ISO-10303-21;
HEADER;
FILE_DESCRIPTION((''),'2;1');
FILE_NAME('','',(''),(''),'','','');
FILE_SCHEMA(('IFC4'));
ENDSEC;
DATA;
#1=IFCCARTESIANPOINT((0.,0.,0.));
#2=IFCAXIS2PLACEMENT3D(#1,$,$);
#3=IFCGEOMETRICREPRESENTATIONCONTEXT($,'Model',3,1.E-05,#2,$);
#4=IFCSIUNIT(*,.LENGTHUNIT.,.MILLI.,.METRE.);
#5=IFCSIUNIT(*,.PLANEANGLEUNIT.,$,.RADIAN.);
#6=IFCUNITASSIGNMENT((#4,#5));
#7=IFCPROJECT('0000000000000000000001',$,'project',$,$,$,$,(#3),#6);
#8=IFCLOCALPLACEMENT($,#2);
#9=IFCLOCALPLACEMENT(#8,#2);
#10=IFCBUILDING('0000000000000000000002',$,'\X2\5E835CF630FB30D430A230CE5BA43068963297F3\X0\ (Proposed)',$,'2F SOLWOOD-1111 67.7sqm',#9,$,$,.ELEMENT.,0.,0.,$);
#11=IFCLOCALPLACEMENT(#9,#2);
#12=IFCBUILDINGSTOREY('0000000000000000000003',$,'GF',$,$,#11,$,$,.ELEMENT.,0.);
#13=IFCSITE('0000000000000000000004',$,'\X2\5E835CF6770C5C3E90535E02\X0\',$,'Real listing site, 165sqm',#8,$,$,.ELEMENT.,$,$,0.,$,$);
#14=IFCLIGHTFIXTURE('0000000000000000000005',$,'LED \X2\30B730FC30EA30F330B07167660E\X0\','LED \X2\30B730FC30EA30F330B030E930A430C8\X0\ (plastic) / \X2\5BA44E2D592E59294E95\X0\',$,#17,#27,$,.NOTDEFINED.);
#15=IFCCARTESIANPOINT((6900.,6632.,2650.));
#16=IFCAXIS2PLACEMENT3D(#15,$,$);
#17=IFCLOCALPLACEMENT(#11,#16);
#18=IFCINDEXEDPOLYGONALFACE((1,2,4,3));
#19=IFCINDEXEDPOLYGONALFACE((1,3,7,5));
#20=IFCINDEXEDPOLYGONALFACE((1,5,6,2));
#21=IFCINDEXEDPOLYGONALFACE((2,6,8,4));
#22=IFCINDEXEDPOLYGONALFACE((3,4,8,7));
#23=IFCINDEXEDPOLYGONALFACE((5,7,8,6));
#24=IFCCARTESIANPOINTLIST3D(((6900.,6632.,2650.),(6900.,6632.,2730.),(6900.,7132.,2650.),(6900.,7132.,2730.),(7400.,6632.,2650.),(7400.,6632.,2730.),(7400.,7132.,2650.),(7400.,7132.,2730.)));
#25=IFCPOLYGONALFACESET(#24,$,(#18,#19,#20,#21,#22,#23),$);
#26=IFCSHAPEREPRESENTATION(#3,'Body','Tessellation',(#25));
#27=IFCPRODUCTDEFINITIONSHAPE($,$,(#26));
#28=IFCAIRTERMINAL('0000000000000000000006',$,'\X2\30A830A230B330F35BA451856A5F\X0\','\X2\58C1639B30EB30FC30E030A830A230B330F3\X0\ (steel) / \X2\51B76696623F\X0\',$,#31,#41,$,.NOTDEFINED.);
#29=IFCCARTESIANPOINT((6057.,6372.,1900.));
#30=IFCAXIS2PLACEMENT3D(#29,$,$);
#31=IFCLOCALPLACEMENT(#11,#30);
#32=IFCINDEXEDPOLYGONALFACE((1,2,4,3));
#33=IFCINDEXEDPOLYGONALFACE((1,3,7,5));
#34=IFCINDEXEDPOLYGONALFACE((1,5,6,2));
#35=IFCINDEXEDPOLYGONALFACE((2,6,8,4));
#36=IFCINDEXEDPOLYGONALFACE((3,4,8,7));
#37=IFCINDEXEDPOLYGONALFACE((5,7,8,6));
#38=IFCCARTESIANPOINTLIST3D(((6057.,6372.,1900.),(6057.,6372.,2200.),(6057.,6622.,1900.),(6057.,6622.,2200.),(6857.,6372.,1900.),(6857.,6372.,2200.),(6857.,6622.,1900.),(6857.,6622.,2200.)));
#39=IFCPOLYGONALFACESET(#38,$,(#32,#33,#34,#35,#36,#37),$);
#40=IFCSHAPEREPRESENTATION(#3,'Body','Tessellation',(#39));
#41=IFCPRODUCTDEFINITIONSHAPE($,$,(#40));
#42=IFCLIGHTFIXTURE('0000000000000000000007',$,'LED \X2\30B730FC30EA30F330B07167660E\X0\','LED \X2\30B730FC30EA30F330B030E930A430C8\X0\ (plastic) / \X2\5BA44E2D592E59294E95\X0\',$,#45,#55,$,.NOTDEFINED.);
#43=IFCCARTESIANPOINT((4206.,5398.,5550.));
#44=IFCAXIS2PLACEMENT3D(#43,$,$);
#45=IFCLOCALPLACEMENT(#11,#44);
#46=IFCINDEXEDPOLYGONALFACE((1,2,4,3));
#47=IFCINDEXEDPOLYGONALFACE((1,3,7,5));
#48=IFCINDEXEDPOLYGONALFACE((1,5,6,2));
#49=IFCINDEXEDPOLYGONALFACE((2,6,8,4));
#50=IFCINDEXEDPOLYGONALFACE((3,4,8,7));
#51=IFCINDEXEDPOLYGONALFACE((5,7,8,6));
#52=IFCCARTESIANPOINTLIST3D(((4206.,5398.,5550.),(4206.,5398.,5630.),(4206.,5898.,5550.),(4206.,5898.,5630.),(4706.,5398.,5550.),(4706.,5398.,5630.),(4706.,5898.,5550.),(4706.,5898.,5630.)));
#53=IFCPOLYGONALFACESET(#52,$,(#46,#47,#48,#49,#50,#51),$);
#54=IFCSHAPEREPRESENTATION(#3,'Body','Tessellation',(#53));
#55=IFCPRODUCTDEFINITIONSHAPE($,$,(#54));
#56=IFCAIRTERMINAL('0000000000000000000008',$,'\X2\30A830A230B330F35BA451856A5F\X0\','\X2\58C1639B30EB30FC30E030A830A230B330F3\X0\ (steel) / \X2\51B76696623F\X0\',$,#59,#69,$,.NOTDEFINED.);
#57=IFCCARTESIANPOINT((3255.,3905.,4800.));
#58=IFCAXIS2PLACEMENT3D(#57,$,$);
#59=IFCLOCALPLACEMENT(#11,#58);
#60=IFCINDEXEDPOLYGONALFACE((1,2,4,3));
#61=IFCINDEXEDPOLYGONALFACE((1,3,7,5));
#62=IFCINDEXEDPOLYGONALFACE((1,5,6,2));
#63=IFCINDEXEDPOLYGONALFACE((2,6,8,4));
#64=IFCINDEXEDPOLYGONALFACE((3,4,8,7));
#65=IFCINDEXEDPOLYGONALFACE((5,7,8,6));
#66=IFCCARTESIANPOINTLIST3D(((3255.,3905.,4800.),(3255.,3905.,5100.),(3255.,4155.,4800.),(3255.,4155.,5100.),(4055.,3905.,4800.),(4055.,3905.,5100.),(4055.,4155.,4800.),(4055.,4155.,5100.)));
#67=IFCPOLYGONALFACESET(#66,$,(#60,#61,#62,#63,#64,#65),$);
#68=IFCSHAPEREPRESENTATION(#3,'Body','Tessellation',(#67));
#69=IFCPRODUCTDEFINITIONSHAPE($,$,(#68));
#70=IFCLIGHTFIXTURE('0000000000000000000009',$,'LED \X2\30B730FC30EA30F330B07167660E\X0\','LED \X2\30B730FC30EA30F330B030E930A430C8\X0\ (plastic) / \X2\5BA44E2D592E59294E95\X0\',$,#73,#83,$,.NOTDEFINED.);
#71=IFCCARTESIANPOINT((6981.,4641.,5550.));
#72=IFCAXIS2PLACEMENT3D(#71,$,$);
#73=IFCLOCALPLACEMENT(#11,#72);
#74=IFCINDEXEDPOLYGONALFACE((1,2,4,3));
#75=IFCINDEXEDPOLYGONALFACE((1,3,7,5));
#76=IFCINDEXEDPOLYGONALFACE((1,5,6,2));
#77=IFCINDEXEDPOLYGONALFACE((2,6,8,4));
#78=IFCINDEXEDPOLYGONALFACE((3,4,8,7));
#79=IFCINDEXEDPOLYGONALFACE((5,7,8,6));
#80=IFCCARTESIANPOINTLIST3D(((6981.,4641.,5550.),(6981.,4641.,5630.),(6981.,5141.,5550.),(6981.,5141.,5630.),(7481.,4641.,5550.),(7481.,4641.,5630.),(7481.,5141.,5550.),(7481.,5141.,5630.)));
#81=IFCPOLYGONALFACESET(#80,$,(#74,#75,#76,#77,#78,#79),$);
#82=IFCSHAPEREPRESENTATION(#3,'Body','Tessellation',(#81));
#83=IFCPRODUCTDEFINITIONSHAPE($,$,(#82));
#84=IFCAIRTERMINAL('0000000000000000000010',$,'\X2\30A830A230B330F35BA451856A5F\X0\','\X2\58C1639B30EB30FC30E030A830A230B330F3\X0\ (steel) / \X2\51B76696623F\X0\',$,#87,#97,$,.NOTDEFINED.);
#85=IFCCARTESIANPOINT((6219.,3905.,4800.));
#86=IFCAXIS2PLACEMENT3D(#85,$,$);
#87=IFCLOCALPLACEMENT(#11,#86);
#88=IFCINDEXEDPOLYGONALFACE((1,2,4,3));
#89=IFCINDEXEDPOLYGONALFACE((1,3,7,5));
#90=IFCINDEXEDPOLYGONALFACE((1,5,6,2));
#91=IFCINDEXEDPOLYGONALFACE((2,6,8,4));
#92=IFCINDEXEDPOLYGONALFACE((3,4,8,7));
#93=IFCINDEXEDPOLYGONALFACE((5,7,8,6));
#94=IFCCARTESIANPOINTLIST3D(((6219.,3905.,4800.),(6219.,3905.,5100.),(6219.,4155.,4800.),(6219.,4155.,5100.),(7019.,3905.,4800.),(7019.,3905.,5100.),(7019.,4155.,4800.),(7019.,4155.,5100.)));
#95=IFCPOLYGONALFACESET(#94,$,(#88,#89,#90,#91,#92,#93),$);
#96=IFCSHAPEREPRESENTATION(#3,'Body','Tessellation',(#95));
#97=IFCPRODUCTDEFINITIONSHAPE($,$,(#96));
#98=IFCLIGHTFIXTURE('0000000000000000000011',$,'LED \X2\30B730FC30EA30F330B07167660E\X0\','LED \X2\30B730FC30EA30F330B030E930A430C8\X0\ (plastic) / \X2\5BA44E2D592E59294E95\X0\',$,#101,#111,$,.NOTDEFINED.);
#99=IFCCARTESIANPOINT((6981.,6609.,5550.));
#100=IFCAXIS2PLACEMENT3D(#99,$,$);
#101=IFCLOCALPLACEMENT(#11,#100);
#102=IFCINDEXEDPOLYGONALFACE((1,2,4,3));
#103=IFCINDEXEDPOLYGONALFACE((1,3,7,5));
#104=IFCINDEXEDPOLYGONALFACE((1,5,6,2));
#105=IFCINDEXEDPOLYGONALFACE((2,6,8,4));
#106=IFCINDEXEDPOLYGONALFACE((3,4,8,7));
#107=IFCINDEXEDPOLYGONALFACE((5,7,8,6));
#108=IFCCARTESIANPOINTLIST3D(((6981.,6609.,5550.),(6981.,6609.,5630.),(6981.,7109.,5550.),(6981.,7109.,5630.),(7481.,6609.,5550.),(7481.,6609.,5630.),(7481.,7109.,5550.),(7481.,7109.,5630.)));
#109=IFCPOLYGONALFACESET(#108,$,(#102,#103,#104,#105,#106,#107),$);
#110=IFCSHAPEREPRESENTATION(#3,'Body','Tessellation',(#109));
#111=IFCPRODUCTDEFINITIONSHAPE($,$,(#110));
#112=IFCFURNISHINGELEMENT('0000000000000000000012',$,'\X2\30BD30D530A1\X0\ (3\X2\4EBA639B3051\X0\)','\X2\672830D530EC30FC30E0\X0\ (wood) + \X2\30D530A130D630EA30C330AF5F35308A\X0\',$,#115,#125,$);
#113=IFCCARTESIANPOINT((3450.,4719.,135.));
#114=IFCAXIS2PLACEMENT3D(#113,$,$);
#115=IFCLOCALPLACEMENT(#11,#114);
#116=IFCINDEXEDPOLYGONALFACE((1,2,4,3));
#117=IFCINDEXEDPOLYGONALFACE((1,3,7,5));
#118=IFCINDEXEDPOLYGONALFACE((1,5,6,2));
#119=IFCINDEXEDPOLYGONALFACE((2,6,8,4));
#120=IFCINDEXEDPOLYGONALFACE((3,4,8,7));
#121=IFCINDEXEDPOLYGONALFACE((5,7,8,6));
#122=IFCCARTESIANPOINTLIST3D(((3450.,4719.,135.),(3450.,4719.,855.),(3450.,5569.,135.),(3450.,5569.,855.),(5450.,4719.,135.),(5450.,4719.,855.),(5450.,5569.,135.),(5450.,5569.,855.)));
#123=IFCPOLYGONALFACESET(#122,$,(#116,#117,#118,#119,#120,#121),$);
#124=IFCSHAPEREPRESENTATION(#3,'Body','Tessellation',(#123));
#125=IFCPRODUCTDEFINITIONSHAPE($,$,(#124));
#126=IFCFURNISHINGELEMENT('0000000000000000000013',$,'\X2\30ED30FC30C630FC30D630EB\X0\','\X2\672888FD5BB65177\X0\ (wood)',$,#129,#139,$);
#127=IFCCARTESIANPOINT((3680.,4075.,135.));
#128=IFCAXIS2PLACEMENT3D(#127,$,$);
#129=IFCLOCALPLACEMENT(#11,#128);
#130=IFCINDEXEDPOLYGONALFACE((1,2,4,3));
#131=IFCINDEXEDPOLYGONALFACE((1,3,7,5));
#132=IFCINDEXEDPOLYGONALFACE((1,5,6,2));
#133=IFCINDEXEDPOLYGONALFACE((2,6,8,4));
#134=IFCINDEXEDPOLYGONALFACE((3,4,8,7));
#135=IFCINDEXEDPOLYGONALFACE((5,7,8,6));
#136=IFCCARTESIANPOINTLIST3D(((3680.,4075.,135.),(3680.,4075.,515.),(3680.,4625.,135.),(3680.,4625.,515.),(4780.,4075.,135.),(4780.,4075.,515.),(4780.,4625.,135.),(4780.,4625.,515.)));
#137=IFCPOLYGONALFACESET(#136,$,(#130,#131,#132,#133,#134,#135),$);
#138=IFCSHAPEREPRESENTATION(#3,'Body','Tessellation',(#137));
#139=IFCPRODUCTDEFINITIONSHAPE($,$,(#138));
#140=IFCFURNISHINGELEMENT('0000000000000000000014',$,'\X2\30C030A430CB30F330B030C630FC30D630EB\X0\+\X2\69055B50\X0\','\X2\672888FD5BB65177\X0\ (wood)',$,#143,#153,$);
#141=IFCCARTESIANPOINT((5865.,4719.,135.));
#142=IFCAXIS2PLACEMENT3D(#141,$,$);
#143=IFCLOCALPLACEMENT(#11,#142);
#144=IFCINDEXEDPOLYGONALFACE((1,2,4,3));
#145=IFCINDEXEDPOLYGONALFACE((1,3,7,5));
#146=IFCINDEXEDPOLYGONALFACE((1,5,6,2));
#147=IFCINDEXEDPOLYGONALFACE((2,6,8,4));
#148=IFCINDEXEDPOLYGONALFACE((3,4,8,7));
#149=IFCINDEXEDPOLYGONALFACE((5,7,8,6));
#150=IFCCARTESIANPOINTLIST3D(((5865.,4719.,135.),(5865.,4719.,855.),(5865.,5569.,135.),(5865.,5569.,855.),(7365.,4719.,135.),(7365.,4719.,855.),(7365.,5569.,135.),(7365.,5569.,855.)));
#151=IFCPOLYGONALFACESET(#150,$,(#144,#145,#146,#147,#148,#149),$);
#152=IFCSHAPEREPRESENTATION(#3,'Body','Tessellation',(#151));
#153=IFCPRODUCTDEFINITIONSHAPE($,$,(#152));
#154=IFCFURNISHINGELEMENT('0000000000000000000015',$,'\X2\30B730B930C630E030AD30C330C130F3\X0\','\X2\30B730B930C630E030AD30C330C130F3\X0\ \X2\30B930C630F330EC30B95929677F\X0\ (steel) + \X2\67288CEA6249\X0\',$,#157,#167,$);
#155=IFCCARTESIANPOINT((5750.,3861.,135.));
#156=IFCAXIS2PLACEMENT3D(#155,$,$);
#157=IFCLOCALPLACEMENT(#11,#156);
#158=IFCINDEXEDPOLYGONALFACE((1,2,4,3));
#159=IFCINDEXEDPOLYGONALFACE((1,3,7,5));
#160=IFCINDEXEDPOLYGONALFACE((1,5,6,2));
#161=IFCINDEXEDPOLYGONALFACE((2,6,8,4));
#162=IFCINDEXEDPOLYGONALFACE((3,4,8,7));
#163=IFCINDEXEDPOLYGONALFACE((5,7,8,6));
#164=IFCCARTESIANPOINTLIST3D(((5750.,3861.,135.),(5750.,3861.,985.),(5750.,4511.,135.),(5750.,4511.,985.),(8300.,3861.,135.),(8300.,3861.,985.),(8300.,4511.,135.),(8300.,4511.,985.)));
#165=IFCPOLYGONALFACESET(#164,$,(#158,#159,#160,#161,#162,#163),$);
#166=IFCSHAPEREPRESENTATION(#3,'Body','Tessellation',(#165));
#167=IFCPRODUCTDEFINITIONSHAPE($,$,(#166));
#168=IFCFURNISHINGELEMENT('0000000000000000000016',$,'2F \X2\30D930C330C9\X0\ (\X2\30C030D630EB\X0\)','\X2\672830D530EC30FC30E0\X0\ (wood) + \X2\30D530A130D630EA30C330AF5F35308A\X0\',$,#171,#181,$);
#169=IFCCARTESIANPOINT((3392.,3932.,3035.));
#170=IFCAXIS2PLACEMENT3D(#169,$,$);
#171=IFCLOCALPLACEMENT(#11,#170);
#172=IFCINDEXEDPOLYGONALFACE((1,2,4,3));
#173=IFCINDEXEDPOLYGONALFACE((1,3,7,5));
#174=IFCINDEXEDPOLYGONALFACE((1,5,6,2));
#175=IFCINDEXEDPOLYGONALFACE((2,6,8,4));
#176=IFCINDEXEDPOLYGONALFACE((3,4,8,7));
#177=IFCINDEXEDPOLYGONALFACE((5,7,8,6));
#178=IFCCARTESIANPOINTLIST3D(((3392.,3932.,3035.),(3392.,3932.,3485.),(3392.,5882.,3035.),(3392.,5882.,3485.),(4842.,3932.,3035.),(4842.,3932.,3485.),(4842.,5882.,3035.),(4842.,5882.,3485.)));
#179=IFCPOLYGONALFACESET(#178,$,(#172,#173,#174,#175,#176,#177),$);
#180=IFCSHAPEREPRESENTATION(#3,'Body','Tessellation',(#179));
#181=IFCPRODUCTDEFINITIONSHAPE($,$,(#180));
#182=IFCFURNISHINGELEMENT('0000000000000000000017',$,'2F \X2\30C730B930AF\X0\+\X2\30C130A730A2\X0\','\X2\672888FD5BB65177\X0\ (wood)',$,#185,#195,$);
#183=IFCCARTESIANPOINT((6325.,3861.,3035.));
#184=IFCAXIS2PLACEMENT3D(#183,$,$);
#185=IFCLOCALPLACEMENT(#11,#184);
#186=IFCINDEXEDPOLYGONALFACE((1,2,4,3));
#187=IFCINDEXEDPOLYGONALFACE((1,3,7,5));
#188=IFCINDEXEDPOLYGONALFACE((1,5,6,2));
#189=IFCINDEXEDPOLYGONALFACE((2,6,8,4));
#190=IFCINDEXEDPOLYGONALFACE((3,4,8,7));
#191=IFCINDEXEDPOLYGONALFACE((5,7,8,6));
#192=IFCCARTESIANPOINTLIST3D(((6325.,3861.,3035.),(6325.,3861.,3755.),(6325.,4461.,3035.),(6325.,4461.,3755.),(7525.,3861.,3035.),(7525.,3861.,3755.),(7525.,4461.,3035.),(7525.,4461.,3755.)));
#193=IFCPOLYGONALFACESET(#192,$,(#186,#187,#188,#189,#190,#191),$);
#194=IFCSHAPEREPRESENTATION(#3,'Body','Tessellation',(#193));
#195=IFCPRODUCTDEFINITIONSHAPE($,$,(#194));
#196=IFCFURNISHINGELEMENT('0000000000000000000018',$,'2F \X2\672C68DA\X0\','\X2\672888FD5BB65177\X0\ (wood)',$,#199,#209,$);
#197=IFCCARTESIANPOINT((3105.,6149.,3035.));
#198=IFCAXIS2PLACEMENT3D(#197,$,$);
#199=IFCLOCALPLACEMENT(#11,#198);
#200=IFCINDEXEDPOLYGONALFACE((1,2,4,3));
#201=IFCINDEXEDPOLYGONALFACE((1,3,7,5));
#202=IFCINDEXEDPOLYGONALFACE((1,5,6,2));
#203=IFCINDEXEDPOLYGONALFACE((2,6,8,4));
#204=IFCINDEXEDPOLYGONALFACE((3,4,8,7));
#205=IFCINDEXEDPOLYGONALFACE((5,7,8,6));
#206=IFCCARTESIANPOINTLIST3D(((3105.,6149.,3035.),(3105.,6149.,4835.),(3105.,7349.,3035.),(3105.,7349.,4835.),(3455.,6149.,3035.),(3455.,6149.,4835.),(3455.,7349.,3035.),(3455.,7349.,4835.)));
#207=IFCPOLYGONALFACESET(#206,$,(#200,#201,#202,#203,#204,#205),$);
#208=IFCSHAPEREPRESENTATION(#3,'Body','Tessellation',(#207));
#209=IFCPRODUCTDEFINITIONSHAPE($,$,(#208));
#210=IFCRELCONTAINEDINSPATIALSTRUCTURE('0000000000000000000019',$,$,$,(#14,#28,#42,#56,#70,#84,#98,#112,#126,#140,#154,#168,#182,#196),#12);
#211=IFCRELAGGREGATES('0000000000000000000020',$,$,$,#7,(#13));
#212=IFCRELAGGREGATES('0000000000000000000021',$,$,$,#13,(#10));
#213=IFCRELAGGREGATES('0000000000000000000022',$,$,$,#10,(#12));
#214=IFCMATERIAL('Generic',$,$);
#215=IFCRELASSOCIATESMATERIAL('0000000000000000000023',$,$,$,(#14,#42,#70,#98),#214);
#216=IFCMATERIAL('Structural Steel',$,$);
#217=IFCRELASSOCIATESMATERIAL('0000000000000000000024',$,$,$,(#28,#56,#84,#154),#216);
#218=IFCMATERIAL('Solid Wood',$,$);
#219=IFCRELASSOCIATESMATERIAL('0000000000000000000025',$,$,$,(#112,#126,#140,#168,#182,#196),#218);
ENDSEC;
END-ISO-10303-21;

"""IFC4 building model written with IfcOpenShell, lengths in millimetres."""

from ifc_helpers import new_model, si_unit, frame, frame_2d, origin, place, context, project, spatial, rectangle, extrude, material, element, save


model = new_model("IFC4")

# Units and contexts
model_context = context("Model", 3, precision=1e-05, world=origin())
ifc_project = project(units=[si_unit("LENGTHUNIT", "METRE", prefix="MILLI"), si_unit("PLANEANGLEUNIT", "RADIAN")], contexts=[model_context])

# Site, building, storey
site_placement = place(None, origin())
site = spatial("IfcSite", under=ifc_project, at=site_placement, Name="広島県尾道市", ObjectType="Real listing site, 165sqm", CompositionType="ELEMENT", RefElevation=0.0)
building_placement = place(site_placement, origin())
building = spatial("IfcBuilding", under=site, at=building_placement, Name="広島・ピアノ室と防音 (Proposed)", ObjectType="2F SOLWOOD-1111 67.7sqm", CompositionType="ELEMENT", ElevationOfRefHeight=0.0, ElevationOfTerrain=0.0)
storey_placement = place(building_placement, origin())
storey = spatial("IfcBuildingStorey", under=building, at=storey_placement, Name="GF", CompositionType="ELEMENT", Elevation=0.0)

# Shared definitions
ifc_material_1 = material(Name="Solid Wood")

# Shared definitions
ifc_material_2 = material(Name="Structural Steel")

# Shared definitions
ifc_material_3 = material(Name="Generic")

# Light fixture
light_fixture_1_placement = place(storey_placement, frame((6900.0, 6632.0, 2650.0)))
element("IfcLightFixture", 1, at=light_fixture_1_placement, inside=storey, material=ifc_material_3, Name="LED シーリング照明", Description="LED シーリングライト (plastic) / 室中央天井", PredefinedType="NOTDEFINED", context=model_context, shape_type="SweptSolid", body=[
    extrude(rectangle(XDim=500.0, YDim=500.0, at=frame_2d((250.0, 250.0))), frame((6900.0, 6632.0, 2650.0)), (0.0, 0.0, 1.0), 80.0),
])

# Air terminal
air_terminal_1_placement = place(storey_placement, frame((6057.0, 6372.0, 1900.0)))
element("IfcAirTerminal", 2, at=air_terminal_1_placement, inside=storey, material=ifc_material_2, Name="エアコン室内機", Description="壁掛ルームエアコン (steel) / 冷暖房", PredefinedType="NOTDEFINED", context=model_context, shape_type="SweptSolid", body=[
    extrude(rectangle(XDim=800.0, YDim=250.0, at=frame_2d((400.0, 125.0))), frame((6057.0, 6372.0, 1900.0)), (0.0, 0.0, 1.0), 300.0),
])

# Light fixture
light_fixture_2_placement = place(storey_placement, frame((4206.0, 5398.0, 5550.0)))
element("IfcLightFixture", 3, at=light_fixture_2_placement, inside=storey, material=ifc_material_3, Name="LED シーリング照明", Description="LED シーリングライト (plastic) / 室中央天井", PredefinedType="NOTDEFINED", context=model_context, shape_type="SweptSolid", body=[
    extrude(rectangle(XDim=500.0, YDim=500.0, at=frame_2d((250.0, 250.0))), frame((4206.0, 5398.0, 5550.0)), (0.0, 0.0, 1.0), 80.0),
])

# Air terminal
air_terminal_2_placement = place(storey_placement, frame((3255.0, 3905.0, 4800.0)))
element("IfcAirTerminal", 4, at=air_terminal_2_placement, inside=storey, material=ifc_material_2, Name="エアコン室内機", Description="壁掛ルームエアコン (steel) / 冷暖房", PredefinedType="NOTDEFINED", context=model_context, shape_type="SweptSolid", body=[
    extrude(rectangle(XDim=800.0, YDim=250.0, at=frame_2d((400.0, 125.0))), frame((3255.0, 3905.0, 4800.0)), (0.0, 0.0, 1.0), 300.0),
])

# Light fixture
light_fixture_3_placement = place(storey_placement, frame((6981.0, 4641.0, 5550.0)))
element("IfcLightFixture", 5, at=light_fixture_3_placement, inside=storey, material=ifc_material_3, Name="LED シーリング照明", Description="LED シーリングライト (plastic) / 室中央天井", PredefinedType="NOTDEFINED", context=model_context, shape_type="SweptSolid", body=[
    extrude(rectangle(XDim=500.0, YDim=500.0, at=frame_2d((250.0, 250.0))), frame((6981.0, 4641.0, 5550.0)), (0.0, 0.0, 1.0), 80.0),
])

# Air terminal
air_terminal_3_placement = place(storey_placement, frame((6219.0, 3905.0, 4800.0)))
element("IfcAirTerminal", 6, at=air_terminal_3_placement, inside=storey, material=ifc_material_2, Name="エアコン室内機", Description="壁掛ルームエアコン (steel) / 冷暖房", PredefinedType="NOTDEFINED", context=model_context, shape_type="SweptSolid", body=[
    extrude(rectangle(XDim=800.0, YDim=250.0, at=frame_2d((400.0, 125.0))), frame((6219.0, 3905.0, 4800.0)), (0.0, 0.0, 1.0), 300.0),
])

# Light fixture
light_fixture_4_placement = place(storey_placement, frame((6981.0, 6609.0, 5550.0)))
element("IfcLightFixture", 7, at=light_fixture_4_placement, inside=storey, material=ifc_material_3, Name="LED シーリング照明", Description="LED シーリングライト (plastic) / 室中央天井", PredefinedType="NOTDEFINED", context=model_context, shape_type="SweptSolid", body=[
    extrude(rectangle(XDim=500.0, YDim=500.0, at=frame_2d((250.0, 250.0))), frame((6981.0, 6609.0, 5550.0)), (0.0, 0.0, 1.0), 80.0),
])

# Furnishing elements
furnishing_1_placement = place(storey_placement, frame((3450.0, 4719.0, 135.0)))
element("IfcFurnishingElement", 8, at=furnishing_1_placement, inside=storey, material=ifc_material_1, Name="ソファ (3人掛け)", Description="木フレーム (wood) + ファブリック張り", context=model_context, shape_type="SweptSolid", body=[
    extrude(rectangle(XDim=2000.0, YDim=850.0, at=frame_2d((1000.0, 425.0))), frame((3450.0, 4719.0, 135.0)), (0.0, 0.0, 1.0), 720.0),
])
furnishing_2_placement = place(storey_placement, frame((3680.0, 4075.0, 135.0)))
element("IfcFurnishingElement", 9, at=furnishing_2_placement, inside=storey, material=ifc_material_1, Name="ローテーブル", Description="木製家具 (wood)", context=model_context, shape_type="SweptSolid", body=[
    extrude(rectangle(XDim=1100.0, YDim=550.0, at=frame_2d((550.0, 275.0))), frame((3680.0, 4075.0, 135.0)), (0.0, 0.0, 1.0), 380.0),
])
furnishing_3_placement = place(storey_placement, frame((5865.0, 4719.0, 135.0)))
element("IfcFurnishingElement", 10, at=furnishing_3_placement, inside=storey, material=ifc_material_1, Name="ダイニングテーブル+椅子", Description="木製家具 (wood)", context=model_context, shape_type="SweptSolid", body=[
    extrude(rectangle(XDim=1500.0, YDim=850.0, at=frame_2d((750.0, 425.0))), frame((5865.0, 4719.0, 135.0)), (0.0, 0.0, 1.0), 720.0),
])
furnishing_4_placement = place(storey_placement, frame((5750.0, 3861.0, 135.0)))
element("IfcFurnishingElement", 11, at=furnishing_4_placement, inside=storey, material=ifc_material_2, Name="システムキッチン", Description="システムキッチン ステンレス天板 (steel) + 木質扉", context=model_context, shape_type="SweptSolid", body=[
    extrude(rectangle(XDim=2550.0, YDim=650.0, at=frame_2d((1275.0, 325.0))), frame((5750.0, 3861.0, 135.0)), (0.0, 0.0, 1.0), 850.0),
])
furnishing_5_placement = place(storey_placement, frame((3392.0, 3932.0, 3035.0)))
element("IfcFurnishingElement", 12, at=furnishing_5_placement, inside=storey, material=ifc_material_1, Name="2F ベッド (ダブル)", Description="木フレーム (wood) + ファブリック張り", context=model_context, shape_type="SweptSolid", body=[
    extrude(rectangle(XDim=1450.0, YDim=1950.0, at=frame_2d((725.0, 975.0))), frame((3392.0, 3932.0, 3035.0)), (0.0, 0.0, 1.0), 450.0),
])
furnishing_6_placement = place(storey_placement, frame((6325.0, 3861.0, 3035.0)))
element("IfcFurnishingElement", 13, at=furnishing_6_placement, inside=storey, material=ifc_material_1, Name="2F デスク+チェア", Description="木製家具 (wood)", context=model_context, shape_type="SweptSolid", body=[
    extrude(rectangle(XDim=1200.0, YDim=600.0, at=frame_2d((600.0, 300.0))), frame((6325.0, 3861.0, 3035.0)), (0.0, 0.0, 1.0), 720.0),
])
furnishing_7_placement = place(storey_placement, frame((3105.0, 6149.0, 3035.0)))
element("IfcFurnishingElement", 14, at=furnishing_7_placement, inside=storey, material=ifc_material_1, Name="2F 本棚", Description="木製家具 (wood)", context=model_context, shape_type="SweptSolid", body=[
    extrude(rectangle(XDim=350.0, YDim=1200.0, at=frame_2d((175.0, 600.0))), frame((3105.0, 6149.0, 3035.0)), (0.0, 0.0, 1.0), 1800.0),
])

save(model, "model.ifc")
